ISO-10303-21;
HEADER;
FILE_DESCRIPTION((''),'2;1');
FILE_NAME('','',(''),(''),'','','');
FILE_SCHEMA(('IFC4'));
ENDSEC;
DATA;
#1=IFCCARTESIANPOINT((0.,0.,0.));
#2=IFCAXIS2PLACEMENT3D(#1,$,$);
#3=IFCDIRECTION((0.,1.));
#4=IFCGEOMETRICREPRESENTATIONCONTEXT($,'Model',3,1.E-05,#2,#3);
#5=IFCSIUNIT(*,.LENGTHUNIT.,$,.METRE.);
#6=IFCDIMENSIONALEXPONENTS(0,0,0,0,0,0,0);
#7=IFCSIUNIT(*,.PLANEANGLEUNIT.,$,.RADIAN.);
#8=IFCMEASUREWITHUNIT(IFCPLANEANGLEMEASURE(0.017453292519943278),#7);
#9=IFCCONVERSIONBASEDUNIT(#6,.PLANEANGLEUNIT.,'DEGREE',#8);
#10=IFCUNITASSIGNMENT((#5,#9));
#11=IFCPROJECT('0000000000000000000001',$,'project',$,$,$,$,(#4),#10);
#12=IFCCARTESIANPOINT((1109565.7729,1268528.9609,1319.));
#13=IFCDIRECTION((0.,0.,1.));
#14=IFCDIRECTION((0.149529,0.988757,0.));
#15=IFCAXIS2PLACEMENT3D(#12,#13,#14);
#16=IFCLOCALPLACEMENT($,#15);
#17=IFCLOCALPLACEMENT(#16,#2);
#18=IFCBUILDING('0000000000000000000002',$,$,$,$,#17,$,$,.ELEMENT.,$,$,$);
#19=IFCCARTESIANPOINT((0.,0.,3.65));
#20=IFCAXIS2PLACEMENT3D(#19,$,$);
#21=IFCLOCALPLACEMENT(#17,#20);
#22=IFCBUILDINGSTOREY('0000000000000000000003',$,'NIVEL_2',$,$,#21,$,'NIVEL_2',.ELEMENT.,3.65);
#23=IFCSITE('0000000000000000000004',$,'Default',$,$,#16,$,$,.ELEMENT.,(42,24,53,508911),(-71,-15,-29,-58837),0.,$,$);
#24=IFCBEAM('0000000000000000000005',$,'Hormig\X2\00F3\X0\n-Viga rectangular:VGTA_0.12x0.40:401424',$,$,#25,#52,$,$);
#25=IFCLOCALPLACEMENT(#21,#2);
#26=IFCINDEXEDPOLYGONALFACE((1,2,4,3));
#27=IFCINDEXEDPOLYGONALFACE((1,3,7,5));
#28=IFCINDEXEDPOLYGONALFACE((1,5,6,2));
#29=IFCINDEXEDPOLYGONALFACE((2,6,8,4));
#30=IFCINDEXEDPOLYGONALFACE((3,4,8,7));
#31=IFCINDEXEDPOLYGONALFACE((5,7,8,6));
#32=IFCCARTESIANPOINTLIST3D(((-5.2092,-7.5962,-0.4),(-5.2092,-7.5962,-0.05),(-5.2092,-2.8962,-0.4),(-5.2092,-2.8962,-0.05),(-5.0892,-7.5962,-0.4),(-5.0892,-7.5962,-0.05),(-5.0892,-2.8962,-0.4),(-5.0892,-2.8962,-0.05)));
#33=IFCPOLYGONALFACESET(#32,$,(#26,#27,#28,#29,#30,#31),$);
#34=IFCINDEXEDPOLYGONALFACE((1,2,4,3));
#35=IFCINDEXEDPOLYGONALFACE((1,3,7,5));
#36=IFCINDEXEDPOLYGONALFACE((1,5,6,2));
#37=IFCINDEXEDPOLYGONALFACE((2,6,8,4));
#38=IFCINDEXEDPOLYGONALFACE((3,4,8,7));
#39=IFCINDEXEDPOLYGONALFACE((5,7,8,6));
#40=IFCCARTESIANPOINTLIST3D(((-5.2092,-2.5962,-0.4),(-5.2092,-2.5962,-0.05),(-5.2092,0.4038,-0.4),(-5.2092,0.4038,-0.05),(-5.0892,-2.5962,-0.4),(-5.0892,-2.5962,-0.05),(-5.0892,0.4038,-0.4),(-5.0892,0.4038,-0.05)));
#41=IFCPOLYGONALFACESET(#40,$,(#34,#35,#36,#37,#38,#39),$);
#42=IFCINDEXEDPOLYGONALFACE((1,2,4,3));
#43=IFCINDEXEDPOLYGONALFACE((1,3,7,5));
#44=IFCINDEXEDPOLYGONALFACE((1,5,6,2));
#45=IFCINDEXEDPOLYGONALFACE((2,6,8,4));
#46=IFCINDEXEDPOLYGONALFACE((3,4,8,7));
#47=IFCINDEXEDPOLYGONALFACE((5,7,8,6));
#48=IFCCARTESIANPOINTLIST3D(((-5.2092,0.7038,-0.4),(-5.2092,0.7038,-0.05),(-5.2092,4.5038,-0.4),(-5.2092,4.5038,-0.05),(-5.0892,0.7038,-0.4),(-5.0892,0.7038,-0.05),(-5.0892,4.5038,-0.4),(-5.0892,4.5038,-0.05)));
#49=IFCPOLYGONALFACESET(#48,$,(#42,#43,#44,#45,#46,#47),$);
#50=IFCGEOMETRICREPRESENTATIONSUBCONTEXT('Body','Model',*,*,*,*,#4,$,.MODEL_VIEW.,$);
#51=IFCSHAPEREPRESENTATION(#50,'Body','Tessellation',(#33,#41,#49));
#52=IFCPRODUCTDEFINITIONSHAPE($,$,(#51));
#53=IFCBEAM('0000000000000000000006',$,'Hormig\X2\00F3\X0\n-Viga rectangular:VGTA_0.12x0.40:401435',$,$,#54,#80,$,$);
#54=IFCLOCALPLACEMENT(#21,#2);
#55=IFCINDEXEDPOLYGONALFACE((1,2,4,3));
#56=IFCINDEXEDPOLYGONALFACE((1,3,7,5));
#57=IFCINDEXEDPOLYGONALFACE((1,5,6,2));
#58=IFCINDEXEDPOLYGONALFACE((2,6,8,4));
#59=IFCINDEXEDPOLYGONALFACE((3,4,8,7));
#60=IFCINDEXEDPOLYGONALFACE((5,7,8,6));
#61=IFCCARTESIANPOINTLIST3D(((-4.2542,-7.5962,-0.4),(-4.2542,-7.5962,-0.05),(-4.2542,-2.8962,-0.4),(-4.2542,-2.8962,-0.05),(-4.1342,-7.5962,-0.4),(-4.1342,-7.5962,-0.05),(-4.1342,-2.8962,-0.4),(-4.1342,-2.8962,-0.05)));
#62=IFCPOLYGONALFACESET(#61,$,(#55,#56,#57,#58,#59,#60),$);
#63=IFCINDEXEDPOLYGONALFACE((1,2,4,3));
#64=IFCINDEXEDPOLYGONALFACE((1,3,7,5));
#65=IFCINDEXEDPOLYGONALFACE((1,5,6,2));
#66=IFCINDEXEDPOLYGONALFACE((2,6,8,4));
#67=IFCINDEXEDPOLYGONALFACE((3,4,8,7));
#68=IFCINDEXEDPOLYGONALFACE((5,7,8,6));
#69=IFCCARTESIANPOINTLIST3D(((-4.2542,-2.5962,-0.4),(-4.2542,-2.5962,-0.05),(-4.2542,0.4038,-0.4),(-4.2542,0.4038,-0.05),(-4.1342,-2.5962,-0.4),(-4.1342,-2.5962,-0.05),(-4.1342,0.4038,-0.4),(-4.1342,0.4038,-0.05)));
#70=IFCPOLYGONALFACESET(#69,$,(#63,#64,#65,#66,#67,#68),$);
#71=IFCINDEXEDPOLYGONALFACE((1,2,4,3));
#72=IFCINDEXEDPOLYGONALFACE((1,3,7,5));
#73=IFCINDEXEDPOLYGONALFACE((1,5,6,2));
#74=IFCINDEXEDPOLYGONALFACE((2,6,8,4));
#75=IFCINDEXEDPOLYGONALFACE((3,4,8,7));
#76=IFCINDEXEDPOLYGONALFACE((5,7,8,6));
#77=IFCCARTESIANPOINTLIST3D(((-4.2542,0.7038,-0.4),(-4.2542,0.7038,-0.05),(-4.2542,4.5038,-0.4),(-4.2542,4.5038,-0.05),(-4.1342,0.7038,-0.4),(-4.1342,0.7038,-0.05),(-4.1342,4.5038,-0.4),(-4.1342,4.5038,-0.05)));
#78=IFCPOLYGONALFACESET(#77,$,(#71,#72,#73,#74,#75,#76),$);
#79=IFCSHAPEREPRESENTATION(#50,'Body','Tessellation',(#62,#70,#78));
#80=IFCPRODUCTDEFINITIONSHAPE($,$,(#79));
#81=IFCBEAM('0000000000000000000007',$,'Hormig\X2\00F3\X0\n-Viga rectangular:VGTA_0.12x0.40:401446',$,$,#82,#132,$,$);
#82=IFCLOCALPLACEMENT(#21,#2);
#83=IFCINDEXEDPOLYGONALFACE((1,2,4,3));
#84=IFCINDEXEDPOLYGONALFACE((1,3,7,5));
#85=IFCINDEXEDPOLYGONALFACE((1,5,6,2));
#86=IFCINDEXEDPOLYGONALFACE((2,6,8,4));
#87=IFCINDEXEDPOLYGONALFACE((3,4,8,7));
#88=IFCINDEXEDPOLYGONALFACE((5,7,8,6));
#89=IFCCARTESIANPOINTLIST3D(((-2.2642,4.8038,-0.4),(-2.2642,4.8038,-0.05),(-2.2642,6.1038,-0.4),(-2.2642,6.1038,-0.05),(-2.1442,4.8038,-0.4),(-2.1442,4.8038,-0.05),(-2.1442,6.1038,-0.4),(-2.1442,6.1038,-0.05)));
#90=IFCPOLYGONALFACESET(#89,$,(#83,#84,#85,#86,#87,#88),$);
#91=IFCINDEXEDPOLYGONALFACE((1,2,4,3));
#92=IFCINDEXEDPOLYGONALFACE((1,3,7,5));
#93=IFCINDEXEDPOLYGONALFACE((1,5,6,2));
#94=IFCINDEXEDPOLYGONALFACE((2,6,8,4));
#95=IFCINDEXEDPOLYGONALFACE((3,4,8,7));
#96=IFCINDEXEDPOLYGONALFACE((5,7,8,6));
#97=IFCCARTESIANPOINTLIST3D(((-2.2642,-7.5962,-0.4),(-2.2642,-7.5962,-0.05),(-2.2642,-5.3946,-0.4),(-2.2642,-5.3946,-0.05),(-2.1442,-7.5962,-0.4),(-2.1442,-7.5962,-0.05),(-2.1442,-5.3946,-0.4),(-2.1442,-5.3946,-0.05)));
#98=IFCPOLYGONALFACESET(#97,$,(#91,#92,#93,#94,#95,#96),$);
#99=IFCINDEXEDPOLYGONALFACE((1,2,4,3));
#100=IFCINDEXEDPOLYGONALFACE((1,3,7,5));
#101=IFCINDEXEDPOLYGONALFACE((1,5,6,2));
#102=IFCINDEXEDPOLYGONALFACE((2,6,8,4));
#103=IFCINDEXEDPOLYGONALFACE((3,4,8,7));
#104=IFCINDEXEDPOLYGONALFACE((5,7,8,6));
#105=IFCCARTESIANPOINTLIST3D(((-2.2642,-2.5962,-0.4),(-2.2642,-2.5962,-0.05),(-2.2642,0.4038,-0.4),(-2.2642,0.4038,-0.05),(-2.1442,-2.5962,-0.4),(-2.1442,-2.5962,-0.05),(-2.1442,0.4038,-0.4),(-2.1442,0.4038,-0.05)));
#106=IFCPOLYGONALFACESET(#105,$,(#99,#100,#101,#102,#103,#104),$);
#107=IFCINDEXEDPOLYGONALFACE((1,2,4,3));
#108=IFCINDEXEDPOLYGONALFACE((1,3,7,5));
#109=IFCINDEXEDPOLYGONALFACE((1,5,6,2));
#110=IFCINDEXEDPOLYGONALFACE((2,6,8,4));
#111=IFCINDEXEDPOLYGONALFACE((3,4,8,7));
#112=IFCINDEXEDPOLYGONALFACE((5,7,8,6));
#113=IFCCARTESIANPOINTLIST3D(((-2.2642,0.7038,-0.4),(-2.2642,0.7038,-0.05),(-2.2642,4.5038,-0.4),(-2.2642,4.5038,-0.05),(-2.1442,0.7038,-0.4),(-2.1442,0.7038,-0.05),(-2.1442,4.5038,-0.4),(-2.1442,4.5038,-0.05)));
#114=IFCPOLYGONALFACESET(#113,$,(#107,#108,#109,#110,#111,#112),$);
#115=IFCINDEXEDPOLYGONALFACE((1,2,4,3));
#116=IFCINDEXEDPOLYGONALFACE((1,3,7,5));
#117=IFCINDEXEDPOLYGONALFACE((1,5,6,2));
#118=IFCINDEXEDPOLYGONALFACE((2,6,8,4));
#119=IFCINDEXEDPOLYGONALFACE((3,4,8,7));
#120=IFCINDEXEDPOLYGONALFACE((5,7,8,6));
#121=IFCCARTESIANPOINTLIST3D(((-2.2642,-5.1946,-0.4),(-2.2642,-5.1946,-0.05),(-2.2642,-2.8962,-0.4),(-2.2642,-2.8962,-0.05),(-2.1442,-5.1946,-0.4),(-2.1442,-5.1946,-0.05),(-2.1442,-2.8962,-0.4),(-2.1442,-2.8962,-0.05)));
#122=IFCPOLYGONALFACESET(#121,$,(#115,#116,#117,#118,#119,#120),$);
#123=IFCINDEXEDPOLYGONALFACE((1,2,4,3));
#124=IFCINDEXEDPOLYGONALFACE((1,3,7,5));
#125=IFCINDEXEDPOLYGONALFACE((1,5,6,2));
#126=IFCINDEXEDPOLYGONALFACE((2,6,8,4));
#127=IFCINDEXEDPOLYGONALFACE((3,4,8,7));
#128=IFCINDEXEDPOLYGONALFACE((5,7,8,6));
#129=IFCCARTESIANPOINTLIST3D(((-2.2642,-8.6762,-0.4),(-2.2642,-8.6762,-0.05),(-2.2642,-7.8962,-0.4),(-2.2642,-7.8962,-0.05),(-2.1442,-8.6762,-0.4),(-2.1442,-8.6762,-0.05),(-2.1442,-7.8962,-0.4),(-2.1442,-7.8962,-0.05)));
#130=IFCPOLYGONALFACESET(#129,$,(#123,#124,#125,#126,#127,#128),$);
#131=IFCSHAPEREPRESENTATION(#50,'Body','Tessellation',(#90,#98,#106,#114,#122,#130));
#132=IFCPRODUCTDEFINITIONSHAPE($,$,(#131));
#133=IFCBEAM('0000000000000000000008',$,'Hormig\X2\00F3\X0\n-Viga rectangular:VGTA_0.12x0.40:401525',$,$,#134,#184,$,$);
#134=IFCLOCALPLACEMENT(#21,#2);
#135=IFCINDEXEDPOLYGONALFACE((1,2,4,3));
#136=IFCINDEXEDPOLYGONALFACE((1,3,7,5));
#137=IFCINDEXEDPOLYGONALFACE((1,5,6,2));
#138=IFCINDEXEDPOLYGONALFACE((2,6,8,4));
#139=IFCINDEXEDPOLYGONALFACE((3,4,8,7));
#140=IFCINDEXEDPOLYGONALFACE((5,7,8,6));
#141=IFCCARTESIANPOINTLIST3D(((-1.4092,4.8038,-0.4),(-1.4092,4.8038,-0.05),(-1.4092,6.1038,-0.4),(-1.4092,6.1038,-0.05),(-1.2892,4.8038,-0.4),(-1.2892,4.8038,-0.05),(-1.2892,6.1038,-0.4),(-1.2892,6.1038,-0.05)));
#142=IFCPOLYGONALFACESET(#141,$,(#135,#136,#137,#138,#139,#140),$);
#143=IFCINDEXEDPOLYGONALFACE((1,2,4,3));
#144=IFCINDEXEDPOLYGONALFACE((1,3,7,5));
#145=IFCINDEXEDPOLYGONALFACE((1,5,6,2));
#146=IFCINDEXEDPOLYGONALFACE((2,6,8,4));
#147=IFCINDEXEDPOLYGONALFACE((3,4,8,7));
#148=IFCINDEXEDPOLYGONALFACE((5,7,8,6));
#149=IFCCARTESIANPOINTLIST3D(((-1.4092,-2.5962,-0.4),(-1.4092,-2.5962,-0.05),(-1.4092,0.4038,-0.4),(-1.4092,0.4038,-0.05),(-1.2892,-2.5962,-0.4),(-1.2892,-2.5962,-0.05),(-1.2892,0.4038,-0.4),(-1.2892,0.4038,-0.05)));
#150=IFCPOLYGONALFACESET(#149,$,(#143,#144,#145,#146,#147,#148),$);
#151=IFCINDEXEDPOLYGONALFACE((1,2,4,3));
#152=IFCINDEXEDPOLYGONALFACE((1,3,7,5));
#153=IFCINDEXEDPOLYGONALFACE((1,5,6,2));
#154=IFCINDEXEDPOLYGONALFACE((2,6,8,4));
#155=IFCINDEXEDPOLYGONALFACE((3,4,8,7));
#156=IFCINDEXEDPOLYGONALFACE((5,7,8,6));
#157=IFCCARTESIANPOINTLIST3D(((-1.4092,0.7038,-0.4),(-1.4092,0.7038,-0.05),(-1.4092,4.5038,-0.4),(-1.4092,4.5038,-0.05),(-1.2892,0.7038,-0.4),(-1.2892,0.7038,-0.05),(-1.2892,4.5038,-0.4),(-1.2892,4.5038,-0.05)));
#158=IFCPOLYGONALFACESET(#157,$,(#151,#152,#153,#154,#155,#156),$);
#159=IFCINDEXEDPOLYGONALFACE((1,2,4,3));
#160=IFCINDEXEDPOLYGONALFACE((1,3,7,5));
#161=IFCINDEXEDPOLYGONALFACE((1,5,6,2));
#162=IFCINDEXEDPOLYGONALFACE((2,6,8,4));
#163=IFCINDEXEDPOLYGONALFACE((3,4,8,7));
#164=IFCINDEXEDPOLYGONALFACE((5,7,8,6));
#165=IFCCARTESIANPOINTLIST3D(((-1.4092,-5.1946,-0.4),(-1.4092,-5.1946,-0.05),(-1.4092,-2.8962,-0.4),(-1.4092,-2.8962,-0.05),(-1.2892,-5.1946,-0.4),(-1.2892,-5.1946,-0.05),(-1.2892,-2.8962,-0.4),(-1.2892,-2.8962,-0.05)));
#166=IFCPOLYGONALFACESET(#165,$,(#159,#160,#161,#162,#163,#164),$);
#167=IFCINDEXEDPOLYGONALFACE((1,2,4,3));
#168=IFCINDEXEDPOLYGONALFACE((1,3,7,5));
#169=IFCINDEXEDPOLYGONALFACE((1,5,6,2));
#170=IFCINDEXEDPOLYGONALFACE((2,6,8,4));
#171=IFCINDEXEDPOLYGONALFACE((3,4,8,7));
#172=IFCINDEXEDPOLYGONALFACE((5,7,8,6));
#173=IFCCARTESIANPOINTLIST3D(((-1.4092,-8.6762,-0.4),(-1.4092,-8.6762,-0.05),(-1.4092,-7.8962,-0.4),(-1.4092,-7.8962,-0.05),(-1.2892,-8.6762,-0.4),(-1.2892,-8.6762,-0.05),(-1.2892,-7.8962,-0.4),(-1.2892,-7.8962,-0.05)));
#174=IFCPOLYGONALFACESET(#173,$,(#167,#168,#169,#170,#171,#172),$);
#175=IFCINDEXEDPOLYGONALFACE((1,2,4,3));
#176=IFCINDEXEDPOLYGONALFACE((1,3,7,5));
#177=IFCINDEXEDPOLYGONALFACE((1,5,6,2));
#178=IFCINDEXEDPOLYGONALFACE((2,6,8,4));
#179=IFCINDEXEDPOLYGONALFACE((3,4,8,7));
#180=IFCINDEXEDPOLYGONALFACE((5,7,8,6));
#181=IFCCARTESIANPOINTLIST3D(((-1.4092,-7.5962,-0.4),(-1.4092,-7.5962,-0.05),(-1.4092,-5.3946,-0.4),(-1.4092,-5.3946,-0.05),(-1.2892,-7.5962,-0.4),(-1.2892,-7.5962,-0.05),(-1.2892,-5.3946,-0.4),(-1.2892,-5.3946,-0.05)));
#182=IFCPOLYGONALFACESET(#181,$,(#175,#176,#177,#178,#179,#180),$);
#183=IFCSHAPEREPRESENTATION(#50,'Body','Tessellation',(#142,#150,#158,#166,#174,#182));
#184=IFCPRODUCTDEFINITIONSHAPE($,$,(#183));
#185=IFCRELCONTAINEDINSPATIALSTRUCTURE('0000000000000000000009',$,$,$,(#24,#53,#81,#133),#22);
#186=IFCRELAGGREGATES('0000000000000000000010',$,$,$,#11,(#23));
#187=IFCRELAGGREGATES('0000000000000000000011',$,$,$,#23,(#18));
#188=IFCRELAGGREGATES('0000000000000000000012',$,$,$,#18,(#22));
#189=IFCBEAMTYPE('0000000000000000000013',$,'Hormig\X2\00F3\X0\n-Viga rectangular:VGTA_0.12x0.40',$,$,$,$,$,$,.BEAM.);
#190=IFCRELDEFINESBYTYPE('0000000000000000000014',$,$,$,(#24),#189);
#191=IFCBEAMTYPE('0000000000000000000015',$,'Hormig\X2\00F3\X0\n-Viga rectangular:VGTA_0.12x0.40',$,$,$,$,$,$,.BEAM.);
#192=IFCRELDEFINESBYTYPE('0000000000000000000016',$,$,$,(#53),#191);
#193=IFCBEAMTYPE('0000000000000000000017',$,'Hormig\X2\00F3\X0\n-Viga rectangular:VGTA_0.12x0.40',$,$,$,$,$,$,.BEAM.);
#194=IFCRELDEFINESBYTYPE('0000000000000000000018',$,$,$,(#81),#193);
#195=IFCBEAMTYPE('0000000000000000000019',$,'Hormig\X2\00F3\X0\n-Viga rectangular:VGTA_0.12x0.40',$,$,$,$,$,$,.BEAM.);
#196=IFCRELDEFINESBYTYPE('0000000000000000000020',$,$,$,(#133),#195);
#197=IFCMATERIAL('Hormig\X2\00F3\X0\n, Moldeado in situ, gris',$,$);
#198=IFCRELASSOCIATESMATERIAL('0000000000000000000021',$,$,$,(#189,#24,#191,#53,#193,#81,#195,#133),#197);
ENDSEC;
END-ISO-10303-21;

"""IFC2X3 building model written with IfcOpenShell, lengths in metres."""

from ifc_helpers import new_model, entity, si_unit, converted_unit, direction, frame, frame_2d, origin, place, context, subcontext, project, spatial, rectangle, extrude, source, transform, mapped, material, type_object, type_shapes, element, save


model = new_model("IFC2X3")

# Units and contexts
model_context = context("Model", 3, precision=1e-05, world=origin(), true_north=direction((0.0, 1.0)))
body_context = subcontext(model_context, "Body", "Model", "MODEL_VIEW")
ifc_project = project(units=[si_unit("LENGTHUNIT", "METRE"), converted_unit("PLANEANGLEUNIT", "DEGREE", entity("IfcPlaneAngleMeasure", 0.017453292519943278), si_unit("PLANEANGLEUNIT", "RADIAN"), dimensions=[0, 0, 0, 0, 0, 0, 0])], contexts=[model_context])

# Site, building, storey
site_placement = place(None, frame((1109565.7729, 1268528.9609, 1319.0), z_axis=(0.0, 0.0, 1.0), x_axis=(0.149529, 0.988757, 0.0)))
site = spatial("IfcSite", under=ifc_project, at=site_placement, Name="Default", CompositionType="ELEMENT", RefLatitude=(42, 24, 53, 508911), RefLongitude=(-71, -15, -29, -58837), RefElevation=0.0)
building_placement = place(site_placement, origin())
building = spatial("IfcBuilding", under=site, at=building_placement, CompositionType="ELEMENT")
storey_placement = place(building_placement, frame((0.0, 0.0, 3.65)))
storey = spatial("IfcBuildingStorey", under=building, at=storey_placement, Name="NIVEL_2", LongName="NIVEL_2", CompositionType="ELEMENT", Elevation=3.65)

# Shared definitions
ifc_material_1 = material(Name="Hormigón, Moldeado in situ, gris")

# Beams
beam_type_1 = type_object("IfcBeamType", Name="Hormigón-Viga rectangular:VGTA_0.12x0.40", PredefinedType="BEAM", material=ifc_material_1)
shared_shape_1 = source(origin(), body_context, "Body", "SweptSolid", [
    extrude(rectangle(XDim=0.35, YDim=0.12, at=frame_2d((0.0, 0.0), x_axis=(0.0, 1.0))), frame((-5.1492, -7.5962, 3.425), z_axis=(0.0, 1.0, 0.0), x_axis=(-1.0, 0.0, 0.0)), (0.0, 0.0, 1.0), 4.7),
    extrude(rectangle(XDim=0.35, YDim=0.12, at=frame_2d((0.0, 0.0), x_axis=(0.0, 1.0))), frame((-5.1492, -2.5962, 3.425), z_axis=(0.0, 1.0, 0.0), x_axis=(-1.0, 0.0, 0.0)), (0.0, 0.0, 1.0), 3.0),
    extrude(rectangle(XDim=0.35, YDim=0.12, at=frame_2d((0.0, 0.0), x_axis=(0.0, 1.0))), frame((-5.1492, 0.7038, 3.425), z_axis=(0.0, 1.0, 0.0), x_axis=(-1.0, 0.0, 0.0)), (0.0, 0.0, 1.0), 3.8),
])
type_shapes(beam_type_1, [shared_shape_1])
beam_1_placement = place(storey_placement, frame((0.0, 0.0, -3.65)))
element("IfcBeam", 1, at=beam_1_placement, inside=storey, type_object=beam_type_1, material=ifc_material_1, Name="Hormigón-Viga rectangular:VGTA_0.12x0.40:401424", context=body_context, shape_type="MappedRepresentation", body=[
    mapped(shared_shape_1, transform((0.0, 0.0, 0.0), scale=1.0)),
])
beam_type_2 = type_object("IfcBeamType", Name="Hormigón-Viga rectangular:VGTA_0.12x0.40", PredefinedType="BEAM", material=ifc_material_1)
shared_shape_2 = source(origin(), body_context, "Body", "SweptSolid", [
    extrude(rectangle(XDim=0.35, YDim=0.12, at=frame_2d((0.0, 0.0), x_axis=(0.0, 1.0))), frame((-4.1942, -7.5962, 3.425), z_axis=(0.0, 1.0, 0.0), x_axis=(-1.0, 0.0, 0.0)), (0.0, 0.0, 1.0), 4.7),
    extrude(rectangle(XDim=0.35, YDim=0.12, at=frame_2d((0.0, 0.0), x_axis=(0.0, 1.0))), frame((-4.1942, -2.5962, 3.425), z_axis=(0.0, 1.0, 0.0), x_axis=(-1.0, 0.0, 0.0)), (0.0, 0.0, 1.0), 3.0),
    extrude(rectangle(XDim=0.35, YDim=0.12, at=frame_2d((0.0, 0.0), x_axis=(0.0, 1.0))), frame((-4.1942, 0.7038, 3.425), z_axis=(0.0, 1.0, 0.0), x_axis=(-1.0, 0.0, 0.0)), (0.0, 0.0, 1.0), 3.8),
])
type_shapes(beam_type_2, [shared_shape_2])
beam_2_placement = place(storey_placement, frame((0.0, 0.0, -3.65)))
element("IfcBeam", 2, at=beam_2_placement, inside=storey, type_object=beam_type_2, material=ifc_material_1, Name="Hormigón-Viga rectangular:VGTA_0.12x0.40:401435", context=body_context, shape_type="MappedRepresentation", body=[
    mapped(shared_shape_2, transform((0.0, 0.0, 0.0), scale=1.0)),
])
beam_type_3 = type_object("IfcBeamType", Name="Hormigón-Viga rectangular:VGTA_0.12x0.40", PredefinedType="BEAM", material=ifc_material_1)
shared_shape_3 = source(origin(), body_context, "Body", "SweptSolid", [
    extrude(rectangle(XDim=0.35, YDim=0.12, at=frame_2d((0.0, 0.0), x_axis=(0.0, 1.0))), frame((-2.2042, 4.8038, 3.425), z_axis=(0.0, 1.0, 0.0), x_axis=(-1.0, 0.0, 0.0)), (0.0, 0.0, 1.0), 1.3),
    extrude(rectangle(XDim=0.35, YDim=0.12, at=frame_2d((0.0, 0.0), x_axis=(0.0, 1.0))), frame((-2.2042, -7.5962, 3.425), z_axis=(0.0, 1.0, 0.0), x_axis=(-1.0, 0.0, 0.0)), (0.0, 0.0, 1.0), 2.2016),
    extrude(rectangle(XDim=0.35, YDim=0.12, at=frame_2d((0.0, 0.0), x_axis=(0.0, 1.0))), frame((-2.2042, -2.5962, 3.425), z_axis=(0.0, 1.0, 0.0), x_axis=(-1.0, 0.0, 0.0)), (0.0, 0.0, 1.0), 3.0),
    extrude(rectangle(XDim=0.35, YDim=0.12, at=frame_2d((0.0, 0.0), x_axis=(0.0, 1.0))), frame((-2.2042, 0.7038, 3.425), z_axis=(0.0, 1.0, 0.0), x_axis=(-1.0, 0.0, 0.0)), (0.0, 0.0, 1.0), 3.8),
    extrude(rectangle(XDim=0.35, YDim=0.12, at=frame_2d((0.0, 0.0), x_axis=(0.0, 1.0))), frame((-2.2042, -5.1946, 3.425), z_axis=(0.0, 1.0, 0.0), x_axis=(-1.0, 0.0, 0.0)), (0.0, 0.0, 1.0), 2.2984),
    extrude(rectangle(XDim=0.35, YDim=0.12, at=frame_2d((0.0, 0.0), x_axis=(0.0, 1.0))), frame((-2.2042, -8.6762, 3.425), z_axis=(0.0, 1.0, 0.0), x_axis=(-1.0, 0.0, 0.0)), (0.0, 0.0, 1.0), 0.78),
])
type_shapes(beam_type_3, [shared_shape_3])
beam_3_placement = place(storey_placement, frame((0.0, 0.0, -3.65)))
element("IfcBeam", 3, at=beam_3_placement, inside=storey, type_object=beam_type_3, material=ifc_material_1, Name="Hormigón-Viga rectangular:VGTA_0.12x0.40:401446", context=body_context, shape_type="MappedRepresentation", body=[
    mapped(shared_shape_3, transform((0.0, 0.0, 0.0), scale=1.0)),
])
beam_type_4 = type_object("IfcBeamType", Name="Hormigón-Viga rectangular:VGTA_0.12x0.40", PredefinedType="BEAM", material=ifc_material_1)
shared_shape_4 = source(origin(), body_context, "Body", "SweptSolid", [
    extrude(rectangle(XDim=0.35, YDim=0.12, at=frame_2d((0.0, 0.0), x_axis=(0.0, 1.0))), frame((-1.3492, 4.8038, 3.425), z_axis=(0.0, 1.0, 0.0), x_axis=(-1.0, 0.0, 0.0)), (0.0, 0.0, 1.0), 1.3),
    extrude(rectangle(XDim=0.35, YDim=0.12, at=frame_2d((0.0, 0.0), x_axis=(0.0, 1.0))), frame((-1.3492, -2.5962, 3.425), z_axis=(0.0, 1.0, 0.0), x_axis=(-1.0, 0.0, 0.0)), (0.0, 0.0, 1.0), 3.0),
    extrude(rectangle(XDim=0.35, YDim=0.12, at=frame_2d((0.0, 0.0), x_axis=(0.0, 1.0))), frame((-1.3492, 0.7038, 3.425), z_axis=(0.0, 1.0, 0.0), x_axis=(-1.0, 0.0, 0.0)), (0.0, 0.0, 1.0), 3.8),
    extrude(rectangle(XDim=0.35, YDim=0.12, at=frame_2d((0.0, 0.0), x_axis=(0.0, 1.0))), frame((-1.3492, -5.1946, 3.425), z_axis=(0.0, 1.0, 0.0), x_axis=(-1.0, 0.0, 0.0)), (0.0, 0.0, 1.0), 2.2984),
    extrude(rectangle(XDim=0.35, YDim=0.12, at=frame_2d((0.0, 0.0), x_axis=(0.0, 1.0))), frame((-1.3492, -8.6762, 3.425), z_axis=(0.0, 1.0, 0.0), x_axis=(-1.0, 0.0, 0.0)), (0.0, 0.0, 1.0), 0.78),
    extrude(rectangle(XDim=0.35, YDim=0.12, at=frame_2d((0.0, 0.0), x_axis=(0.0, 1.0))), frame((-1.3492, -7.5962, 3.425), z_axis=(0.0, 1.0, 0.0), x_axis=(-1.0, 0.0, 0.0)), (0.0, 0.0, 1.0), 2.2016),
])
type_shapes(beam_type_4, [shared_shape_4])
beam_4_placement = place(storey_placement, frame((0.0, 0.0, -3.65)))
element("IfcBeam", 4, at=beam_4_placement, inside=storey, type_object=beam_type_4, material=ifc_material_1, Name="Hormigón-Viga rectangular:VGTA_0.12x0.40:401525", context=body_context, shape_type="MappedRepresentation", body=[
    mapped(shared_shape_4, transform((0.0, 0.0, 0.0), scale=1.0)),
])

save(model, "model.ifc")
